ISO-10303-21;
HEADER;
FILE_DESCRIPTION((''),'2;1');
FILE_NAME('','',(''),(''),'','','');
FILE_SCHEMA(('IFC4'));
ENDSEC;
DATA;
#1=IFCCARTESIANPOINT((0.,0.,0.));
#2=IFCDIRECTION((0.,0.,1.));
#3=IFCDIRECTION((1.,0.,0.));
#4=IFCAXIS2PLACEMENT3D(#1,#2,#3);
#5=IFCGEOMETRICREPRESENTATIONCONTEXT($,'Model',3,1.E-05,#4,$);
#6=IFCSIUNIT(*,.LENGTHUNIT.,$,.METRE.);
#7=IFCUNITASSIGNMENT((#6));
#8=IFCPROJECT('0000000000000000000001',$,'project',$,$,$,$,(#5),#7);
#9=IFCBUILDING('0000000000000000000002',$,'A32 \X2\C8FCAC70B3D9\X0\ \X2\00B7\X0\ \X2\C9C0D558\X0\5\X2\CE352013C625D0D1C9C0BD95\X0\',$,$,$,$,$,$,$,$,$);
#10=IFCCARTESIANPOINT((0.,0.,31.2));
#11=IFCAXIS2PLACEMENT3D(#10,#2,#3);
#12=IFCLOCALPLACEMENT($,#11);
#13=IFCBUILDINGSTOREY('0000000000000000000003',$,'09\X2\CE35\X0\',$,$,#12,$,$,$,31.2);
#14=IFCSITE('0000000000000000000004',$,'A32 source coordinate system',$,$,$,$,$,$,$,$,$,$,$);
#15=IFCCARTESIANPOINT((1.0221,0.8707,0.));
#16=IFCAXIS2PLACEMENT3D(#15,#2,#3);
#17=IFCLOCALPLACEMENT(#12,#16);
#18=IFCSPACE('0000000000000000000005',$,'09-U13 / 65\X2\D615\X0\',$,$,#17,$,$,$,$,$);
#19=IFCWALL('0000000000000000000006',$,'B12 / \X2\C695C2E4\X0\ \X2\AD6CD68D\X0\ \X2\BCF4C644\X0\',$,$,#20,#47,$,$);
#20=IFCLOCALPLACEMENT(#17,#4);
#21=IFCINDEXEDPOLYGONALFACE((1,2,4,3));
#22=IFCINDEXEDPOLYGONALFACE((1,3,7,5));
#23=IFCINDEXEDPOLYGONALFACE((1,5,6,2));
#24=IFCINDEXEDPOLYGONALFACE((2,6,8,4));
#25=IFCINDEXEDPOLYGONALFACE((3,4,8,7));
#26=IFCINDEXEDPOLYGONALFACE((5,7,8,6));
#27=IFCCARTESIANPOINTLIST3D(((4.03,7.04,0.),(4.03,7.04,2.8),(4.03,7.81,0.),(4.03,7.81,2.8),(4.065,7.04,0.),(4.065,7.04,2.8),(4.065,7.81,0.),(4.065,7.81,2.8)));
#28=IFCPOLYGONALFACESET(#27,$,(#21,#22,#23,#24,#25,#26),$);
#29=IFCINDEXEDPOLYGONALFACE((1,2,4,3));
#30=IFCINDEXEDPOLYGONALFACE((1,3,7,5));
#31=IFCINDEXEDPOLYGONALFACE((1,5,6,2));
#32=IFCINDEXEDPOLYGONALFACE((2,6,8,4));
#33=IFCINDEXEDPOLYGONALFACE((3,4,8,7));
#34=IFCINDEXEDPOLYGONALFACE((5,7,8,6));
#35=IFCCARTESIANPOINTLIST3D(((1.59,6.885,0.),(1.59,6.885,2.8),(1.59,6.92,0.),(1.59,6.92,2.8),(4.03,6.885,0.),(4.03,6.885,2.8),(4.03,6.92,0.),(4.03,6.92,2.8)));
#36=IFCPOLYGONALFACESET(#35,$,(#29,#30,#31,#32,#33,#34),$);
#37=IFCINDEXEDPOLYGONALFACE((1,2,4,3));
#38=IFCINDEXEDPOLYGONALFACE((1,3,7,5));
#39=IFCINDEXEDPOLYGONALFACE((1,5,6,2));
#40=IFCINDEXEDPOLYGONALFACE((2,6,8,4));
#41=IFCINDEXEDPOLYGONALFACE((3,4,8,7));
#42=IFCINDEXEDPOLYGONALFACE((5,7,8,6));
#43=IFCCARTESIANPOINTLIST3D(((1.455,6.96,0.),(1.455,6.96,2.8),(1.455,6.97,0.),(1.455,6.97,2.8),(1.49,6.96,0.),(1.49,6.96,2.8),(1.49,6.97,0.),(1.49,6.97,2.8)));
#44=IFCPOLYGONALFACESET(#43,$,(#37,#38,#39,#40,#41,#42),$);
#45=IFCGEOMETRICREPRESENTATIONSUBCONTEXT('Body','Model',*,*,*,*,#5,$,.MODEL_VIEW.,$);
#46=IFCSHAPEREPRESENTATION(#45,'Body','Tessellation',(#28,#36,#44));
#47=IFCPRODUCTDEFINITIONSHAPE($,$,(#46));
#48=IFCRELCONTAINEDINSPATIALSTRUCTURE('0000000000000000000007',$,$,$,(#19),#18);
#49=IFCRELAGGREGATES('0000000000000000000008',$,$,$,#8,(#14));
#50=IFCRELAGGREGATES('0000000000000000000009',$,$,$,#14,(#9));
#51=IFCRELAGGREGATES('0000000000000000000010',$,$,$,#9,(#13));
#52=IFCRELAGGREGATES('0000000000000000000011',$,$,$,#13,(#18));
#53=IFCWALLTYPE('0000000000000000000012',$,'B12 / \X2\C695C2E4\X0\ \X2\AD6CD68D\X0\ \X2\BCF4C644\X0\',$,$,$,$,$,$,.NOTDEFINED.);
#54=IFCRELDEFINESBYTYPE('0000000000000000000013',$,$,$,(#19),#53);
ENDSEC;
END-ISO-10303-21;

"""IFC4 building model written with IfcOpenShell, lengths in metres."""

from ifc_helpers import new_model, si_unit, frame, origin, origin_with_axes, place, context, subcontext, project, spatial, polyline, outline, extrude, source, transform, mapped, type_object, type_shapes, element, save


model = new_model("IFC4")

# Units and contexts
model_context = context("Model", 3, precision=1e-05, world=origin_with_axes())
body_context = subcontext(model_context, "Body", "Model", "MODEL_VIEW")
ifc_project = project(units=[si_unit("LENGTHUNIT", "METRE")], contexts=[model_context])

# Site, building, storey, space
storey_placement = place(None, frame((0.0, 0.0, 31.2), z_axis=(0.0, 0.0, 1.0), x_axis=(1.0, 0.0, 0.0)))
space_placement = place(storey_placement, frame((1.0221, 0.8707, 0.0), z_axis=(0.0, 0.0, 1.0), x_axis=(1.0, 0.0, 0.0)))
site = spatial("IfcSite", under=ifc_project, Name="A32 source coordinate system")
building = spatial("IfcBuilding", under=site, Name="A32 주거동 · 지하5층–옥탑지붕")
storey = spatial("IfcBuildingStorey", under=building, at=storey_placement, Name="09층", Elevation=31.2)
space = spatial("IfcSpace", under=storey, at=space_placement, Name="09-U13 / 65형")

# Wall
wall_type_1 = type_object("IfcWallType", Name="B12 / 욕실 구획 보완", PredefinedType="NOTDEFINED")
shared_shape_1 = source(origin(), body_context, "Body", "SweptSolid", [
    extrude(outline(polyline([(4.065, 7.04), (4.03, 7.04), (4.03, 7.81), (4.065, 7.81), (4.065, 7.04)])), origin(), (0.0, 0.0, 1.0), 2.8),
    extrude(outline(polyline([(1.59, 6.92), (4.03, 6.92), (4.03, 6.885), (1.59, 6.885), (1.59, 6.92)])), origin(), (0.0, 0.0, 1.0), 2.8),
    extrude(outline(polyline([(1.455, 6.97), (1.49, 6.97), (1.49, 6.96), (1.455, 6.96), (1.455, 6.97)])), origin(), (0.0, 0.0, 1.0), 2.8),
])
type_shapes(wall_type_1, [shared_shape_1])
wall_1_placement = place(space_placement, origin_with_axes())
element("IfcWall", 1, at=wall_1_placement, inside=space, type_object=wall_type_1, Name="B12 / 욕실 구획 보완", context=body_context, shape_type="MappedRepresentation", body=[
    mapped(shared_shape_1, transform((0.0, 0.0, 0.0), scale=1.0)),
])

save(model, "model.ifc")
